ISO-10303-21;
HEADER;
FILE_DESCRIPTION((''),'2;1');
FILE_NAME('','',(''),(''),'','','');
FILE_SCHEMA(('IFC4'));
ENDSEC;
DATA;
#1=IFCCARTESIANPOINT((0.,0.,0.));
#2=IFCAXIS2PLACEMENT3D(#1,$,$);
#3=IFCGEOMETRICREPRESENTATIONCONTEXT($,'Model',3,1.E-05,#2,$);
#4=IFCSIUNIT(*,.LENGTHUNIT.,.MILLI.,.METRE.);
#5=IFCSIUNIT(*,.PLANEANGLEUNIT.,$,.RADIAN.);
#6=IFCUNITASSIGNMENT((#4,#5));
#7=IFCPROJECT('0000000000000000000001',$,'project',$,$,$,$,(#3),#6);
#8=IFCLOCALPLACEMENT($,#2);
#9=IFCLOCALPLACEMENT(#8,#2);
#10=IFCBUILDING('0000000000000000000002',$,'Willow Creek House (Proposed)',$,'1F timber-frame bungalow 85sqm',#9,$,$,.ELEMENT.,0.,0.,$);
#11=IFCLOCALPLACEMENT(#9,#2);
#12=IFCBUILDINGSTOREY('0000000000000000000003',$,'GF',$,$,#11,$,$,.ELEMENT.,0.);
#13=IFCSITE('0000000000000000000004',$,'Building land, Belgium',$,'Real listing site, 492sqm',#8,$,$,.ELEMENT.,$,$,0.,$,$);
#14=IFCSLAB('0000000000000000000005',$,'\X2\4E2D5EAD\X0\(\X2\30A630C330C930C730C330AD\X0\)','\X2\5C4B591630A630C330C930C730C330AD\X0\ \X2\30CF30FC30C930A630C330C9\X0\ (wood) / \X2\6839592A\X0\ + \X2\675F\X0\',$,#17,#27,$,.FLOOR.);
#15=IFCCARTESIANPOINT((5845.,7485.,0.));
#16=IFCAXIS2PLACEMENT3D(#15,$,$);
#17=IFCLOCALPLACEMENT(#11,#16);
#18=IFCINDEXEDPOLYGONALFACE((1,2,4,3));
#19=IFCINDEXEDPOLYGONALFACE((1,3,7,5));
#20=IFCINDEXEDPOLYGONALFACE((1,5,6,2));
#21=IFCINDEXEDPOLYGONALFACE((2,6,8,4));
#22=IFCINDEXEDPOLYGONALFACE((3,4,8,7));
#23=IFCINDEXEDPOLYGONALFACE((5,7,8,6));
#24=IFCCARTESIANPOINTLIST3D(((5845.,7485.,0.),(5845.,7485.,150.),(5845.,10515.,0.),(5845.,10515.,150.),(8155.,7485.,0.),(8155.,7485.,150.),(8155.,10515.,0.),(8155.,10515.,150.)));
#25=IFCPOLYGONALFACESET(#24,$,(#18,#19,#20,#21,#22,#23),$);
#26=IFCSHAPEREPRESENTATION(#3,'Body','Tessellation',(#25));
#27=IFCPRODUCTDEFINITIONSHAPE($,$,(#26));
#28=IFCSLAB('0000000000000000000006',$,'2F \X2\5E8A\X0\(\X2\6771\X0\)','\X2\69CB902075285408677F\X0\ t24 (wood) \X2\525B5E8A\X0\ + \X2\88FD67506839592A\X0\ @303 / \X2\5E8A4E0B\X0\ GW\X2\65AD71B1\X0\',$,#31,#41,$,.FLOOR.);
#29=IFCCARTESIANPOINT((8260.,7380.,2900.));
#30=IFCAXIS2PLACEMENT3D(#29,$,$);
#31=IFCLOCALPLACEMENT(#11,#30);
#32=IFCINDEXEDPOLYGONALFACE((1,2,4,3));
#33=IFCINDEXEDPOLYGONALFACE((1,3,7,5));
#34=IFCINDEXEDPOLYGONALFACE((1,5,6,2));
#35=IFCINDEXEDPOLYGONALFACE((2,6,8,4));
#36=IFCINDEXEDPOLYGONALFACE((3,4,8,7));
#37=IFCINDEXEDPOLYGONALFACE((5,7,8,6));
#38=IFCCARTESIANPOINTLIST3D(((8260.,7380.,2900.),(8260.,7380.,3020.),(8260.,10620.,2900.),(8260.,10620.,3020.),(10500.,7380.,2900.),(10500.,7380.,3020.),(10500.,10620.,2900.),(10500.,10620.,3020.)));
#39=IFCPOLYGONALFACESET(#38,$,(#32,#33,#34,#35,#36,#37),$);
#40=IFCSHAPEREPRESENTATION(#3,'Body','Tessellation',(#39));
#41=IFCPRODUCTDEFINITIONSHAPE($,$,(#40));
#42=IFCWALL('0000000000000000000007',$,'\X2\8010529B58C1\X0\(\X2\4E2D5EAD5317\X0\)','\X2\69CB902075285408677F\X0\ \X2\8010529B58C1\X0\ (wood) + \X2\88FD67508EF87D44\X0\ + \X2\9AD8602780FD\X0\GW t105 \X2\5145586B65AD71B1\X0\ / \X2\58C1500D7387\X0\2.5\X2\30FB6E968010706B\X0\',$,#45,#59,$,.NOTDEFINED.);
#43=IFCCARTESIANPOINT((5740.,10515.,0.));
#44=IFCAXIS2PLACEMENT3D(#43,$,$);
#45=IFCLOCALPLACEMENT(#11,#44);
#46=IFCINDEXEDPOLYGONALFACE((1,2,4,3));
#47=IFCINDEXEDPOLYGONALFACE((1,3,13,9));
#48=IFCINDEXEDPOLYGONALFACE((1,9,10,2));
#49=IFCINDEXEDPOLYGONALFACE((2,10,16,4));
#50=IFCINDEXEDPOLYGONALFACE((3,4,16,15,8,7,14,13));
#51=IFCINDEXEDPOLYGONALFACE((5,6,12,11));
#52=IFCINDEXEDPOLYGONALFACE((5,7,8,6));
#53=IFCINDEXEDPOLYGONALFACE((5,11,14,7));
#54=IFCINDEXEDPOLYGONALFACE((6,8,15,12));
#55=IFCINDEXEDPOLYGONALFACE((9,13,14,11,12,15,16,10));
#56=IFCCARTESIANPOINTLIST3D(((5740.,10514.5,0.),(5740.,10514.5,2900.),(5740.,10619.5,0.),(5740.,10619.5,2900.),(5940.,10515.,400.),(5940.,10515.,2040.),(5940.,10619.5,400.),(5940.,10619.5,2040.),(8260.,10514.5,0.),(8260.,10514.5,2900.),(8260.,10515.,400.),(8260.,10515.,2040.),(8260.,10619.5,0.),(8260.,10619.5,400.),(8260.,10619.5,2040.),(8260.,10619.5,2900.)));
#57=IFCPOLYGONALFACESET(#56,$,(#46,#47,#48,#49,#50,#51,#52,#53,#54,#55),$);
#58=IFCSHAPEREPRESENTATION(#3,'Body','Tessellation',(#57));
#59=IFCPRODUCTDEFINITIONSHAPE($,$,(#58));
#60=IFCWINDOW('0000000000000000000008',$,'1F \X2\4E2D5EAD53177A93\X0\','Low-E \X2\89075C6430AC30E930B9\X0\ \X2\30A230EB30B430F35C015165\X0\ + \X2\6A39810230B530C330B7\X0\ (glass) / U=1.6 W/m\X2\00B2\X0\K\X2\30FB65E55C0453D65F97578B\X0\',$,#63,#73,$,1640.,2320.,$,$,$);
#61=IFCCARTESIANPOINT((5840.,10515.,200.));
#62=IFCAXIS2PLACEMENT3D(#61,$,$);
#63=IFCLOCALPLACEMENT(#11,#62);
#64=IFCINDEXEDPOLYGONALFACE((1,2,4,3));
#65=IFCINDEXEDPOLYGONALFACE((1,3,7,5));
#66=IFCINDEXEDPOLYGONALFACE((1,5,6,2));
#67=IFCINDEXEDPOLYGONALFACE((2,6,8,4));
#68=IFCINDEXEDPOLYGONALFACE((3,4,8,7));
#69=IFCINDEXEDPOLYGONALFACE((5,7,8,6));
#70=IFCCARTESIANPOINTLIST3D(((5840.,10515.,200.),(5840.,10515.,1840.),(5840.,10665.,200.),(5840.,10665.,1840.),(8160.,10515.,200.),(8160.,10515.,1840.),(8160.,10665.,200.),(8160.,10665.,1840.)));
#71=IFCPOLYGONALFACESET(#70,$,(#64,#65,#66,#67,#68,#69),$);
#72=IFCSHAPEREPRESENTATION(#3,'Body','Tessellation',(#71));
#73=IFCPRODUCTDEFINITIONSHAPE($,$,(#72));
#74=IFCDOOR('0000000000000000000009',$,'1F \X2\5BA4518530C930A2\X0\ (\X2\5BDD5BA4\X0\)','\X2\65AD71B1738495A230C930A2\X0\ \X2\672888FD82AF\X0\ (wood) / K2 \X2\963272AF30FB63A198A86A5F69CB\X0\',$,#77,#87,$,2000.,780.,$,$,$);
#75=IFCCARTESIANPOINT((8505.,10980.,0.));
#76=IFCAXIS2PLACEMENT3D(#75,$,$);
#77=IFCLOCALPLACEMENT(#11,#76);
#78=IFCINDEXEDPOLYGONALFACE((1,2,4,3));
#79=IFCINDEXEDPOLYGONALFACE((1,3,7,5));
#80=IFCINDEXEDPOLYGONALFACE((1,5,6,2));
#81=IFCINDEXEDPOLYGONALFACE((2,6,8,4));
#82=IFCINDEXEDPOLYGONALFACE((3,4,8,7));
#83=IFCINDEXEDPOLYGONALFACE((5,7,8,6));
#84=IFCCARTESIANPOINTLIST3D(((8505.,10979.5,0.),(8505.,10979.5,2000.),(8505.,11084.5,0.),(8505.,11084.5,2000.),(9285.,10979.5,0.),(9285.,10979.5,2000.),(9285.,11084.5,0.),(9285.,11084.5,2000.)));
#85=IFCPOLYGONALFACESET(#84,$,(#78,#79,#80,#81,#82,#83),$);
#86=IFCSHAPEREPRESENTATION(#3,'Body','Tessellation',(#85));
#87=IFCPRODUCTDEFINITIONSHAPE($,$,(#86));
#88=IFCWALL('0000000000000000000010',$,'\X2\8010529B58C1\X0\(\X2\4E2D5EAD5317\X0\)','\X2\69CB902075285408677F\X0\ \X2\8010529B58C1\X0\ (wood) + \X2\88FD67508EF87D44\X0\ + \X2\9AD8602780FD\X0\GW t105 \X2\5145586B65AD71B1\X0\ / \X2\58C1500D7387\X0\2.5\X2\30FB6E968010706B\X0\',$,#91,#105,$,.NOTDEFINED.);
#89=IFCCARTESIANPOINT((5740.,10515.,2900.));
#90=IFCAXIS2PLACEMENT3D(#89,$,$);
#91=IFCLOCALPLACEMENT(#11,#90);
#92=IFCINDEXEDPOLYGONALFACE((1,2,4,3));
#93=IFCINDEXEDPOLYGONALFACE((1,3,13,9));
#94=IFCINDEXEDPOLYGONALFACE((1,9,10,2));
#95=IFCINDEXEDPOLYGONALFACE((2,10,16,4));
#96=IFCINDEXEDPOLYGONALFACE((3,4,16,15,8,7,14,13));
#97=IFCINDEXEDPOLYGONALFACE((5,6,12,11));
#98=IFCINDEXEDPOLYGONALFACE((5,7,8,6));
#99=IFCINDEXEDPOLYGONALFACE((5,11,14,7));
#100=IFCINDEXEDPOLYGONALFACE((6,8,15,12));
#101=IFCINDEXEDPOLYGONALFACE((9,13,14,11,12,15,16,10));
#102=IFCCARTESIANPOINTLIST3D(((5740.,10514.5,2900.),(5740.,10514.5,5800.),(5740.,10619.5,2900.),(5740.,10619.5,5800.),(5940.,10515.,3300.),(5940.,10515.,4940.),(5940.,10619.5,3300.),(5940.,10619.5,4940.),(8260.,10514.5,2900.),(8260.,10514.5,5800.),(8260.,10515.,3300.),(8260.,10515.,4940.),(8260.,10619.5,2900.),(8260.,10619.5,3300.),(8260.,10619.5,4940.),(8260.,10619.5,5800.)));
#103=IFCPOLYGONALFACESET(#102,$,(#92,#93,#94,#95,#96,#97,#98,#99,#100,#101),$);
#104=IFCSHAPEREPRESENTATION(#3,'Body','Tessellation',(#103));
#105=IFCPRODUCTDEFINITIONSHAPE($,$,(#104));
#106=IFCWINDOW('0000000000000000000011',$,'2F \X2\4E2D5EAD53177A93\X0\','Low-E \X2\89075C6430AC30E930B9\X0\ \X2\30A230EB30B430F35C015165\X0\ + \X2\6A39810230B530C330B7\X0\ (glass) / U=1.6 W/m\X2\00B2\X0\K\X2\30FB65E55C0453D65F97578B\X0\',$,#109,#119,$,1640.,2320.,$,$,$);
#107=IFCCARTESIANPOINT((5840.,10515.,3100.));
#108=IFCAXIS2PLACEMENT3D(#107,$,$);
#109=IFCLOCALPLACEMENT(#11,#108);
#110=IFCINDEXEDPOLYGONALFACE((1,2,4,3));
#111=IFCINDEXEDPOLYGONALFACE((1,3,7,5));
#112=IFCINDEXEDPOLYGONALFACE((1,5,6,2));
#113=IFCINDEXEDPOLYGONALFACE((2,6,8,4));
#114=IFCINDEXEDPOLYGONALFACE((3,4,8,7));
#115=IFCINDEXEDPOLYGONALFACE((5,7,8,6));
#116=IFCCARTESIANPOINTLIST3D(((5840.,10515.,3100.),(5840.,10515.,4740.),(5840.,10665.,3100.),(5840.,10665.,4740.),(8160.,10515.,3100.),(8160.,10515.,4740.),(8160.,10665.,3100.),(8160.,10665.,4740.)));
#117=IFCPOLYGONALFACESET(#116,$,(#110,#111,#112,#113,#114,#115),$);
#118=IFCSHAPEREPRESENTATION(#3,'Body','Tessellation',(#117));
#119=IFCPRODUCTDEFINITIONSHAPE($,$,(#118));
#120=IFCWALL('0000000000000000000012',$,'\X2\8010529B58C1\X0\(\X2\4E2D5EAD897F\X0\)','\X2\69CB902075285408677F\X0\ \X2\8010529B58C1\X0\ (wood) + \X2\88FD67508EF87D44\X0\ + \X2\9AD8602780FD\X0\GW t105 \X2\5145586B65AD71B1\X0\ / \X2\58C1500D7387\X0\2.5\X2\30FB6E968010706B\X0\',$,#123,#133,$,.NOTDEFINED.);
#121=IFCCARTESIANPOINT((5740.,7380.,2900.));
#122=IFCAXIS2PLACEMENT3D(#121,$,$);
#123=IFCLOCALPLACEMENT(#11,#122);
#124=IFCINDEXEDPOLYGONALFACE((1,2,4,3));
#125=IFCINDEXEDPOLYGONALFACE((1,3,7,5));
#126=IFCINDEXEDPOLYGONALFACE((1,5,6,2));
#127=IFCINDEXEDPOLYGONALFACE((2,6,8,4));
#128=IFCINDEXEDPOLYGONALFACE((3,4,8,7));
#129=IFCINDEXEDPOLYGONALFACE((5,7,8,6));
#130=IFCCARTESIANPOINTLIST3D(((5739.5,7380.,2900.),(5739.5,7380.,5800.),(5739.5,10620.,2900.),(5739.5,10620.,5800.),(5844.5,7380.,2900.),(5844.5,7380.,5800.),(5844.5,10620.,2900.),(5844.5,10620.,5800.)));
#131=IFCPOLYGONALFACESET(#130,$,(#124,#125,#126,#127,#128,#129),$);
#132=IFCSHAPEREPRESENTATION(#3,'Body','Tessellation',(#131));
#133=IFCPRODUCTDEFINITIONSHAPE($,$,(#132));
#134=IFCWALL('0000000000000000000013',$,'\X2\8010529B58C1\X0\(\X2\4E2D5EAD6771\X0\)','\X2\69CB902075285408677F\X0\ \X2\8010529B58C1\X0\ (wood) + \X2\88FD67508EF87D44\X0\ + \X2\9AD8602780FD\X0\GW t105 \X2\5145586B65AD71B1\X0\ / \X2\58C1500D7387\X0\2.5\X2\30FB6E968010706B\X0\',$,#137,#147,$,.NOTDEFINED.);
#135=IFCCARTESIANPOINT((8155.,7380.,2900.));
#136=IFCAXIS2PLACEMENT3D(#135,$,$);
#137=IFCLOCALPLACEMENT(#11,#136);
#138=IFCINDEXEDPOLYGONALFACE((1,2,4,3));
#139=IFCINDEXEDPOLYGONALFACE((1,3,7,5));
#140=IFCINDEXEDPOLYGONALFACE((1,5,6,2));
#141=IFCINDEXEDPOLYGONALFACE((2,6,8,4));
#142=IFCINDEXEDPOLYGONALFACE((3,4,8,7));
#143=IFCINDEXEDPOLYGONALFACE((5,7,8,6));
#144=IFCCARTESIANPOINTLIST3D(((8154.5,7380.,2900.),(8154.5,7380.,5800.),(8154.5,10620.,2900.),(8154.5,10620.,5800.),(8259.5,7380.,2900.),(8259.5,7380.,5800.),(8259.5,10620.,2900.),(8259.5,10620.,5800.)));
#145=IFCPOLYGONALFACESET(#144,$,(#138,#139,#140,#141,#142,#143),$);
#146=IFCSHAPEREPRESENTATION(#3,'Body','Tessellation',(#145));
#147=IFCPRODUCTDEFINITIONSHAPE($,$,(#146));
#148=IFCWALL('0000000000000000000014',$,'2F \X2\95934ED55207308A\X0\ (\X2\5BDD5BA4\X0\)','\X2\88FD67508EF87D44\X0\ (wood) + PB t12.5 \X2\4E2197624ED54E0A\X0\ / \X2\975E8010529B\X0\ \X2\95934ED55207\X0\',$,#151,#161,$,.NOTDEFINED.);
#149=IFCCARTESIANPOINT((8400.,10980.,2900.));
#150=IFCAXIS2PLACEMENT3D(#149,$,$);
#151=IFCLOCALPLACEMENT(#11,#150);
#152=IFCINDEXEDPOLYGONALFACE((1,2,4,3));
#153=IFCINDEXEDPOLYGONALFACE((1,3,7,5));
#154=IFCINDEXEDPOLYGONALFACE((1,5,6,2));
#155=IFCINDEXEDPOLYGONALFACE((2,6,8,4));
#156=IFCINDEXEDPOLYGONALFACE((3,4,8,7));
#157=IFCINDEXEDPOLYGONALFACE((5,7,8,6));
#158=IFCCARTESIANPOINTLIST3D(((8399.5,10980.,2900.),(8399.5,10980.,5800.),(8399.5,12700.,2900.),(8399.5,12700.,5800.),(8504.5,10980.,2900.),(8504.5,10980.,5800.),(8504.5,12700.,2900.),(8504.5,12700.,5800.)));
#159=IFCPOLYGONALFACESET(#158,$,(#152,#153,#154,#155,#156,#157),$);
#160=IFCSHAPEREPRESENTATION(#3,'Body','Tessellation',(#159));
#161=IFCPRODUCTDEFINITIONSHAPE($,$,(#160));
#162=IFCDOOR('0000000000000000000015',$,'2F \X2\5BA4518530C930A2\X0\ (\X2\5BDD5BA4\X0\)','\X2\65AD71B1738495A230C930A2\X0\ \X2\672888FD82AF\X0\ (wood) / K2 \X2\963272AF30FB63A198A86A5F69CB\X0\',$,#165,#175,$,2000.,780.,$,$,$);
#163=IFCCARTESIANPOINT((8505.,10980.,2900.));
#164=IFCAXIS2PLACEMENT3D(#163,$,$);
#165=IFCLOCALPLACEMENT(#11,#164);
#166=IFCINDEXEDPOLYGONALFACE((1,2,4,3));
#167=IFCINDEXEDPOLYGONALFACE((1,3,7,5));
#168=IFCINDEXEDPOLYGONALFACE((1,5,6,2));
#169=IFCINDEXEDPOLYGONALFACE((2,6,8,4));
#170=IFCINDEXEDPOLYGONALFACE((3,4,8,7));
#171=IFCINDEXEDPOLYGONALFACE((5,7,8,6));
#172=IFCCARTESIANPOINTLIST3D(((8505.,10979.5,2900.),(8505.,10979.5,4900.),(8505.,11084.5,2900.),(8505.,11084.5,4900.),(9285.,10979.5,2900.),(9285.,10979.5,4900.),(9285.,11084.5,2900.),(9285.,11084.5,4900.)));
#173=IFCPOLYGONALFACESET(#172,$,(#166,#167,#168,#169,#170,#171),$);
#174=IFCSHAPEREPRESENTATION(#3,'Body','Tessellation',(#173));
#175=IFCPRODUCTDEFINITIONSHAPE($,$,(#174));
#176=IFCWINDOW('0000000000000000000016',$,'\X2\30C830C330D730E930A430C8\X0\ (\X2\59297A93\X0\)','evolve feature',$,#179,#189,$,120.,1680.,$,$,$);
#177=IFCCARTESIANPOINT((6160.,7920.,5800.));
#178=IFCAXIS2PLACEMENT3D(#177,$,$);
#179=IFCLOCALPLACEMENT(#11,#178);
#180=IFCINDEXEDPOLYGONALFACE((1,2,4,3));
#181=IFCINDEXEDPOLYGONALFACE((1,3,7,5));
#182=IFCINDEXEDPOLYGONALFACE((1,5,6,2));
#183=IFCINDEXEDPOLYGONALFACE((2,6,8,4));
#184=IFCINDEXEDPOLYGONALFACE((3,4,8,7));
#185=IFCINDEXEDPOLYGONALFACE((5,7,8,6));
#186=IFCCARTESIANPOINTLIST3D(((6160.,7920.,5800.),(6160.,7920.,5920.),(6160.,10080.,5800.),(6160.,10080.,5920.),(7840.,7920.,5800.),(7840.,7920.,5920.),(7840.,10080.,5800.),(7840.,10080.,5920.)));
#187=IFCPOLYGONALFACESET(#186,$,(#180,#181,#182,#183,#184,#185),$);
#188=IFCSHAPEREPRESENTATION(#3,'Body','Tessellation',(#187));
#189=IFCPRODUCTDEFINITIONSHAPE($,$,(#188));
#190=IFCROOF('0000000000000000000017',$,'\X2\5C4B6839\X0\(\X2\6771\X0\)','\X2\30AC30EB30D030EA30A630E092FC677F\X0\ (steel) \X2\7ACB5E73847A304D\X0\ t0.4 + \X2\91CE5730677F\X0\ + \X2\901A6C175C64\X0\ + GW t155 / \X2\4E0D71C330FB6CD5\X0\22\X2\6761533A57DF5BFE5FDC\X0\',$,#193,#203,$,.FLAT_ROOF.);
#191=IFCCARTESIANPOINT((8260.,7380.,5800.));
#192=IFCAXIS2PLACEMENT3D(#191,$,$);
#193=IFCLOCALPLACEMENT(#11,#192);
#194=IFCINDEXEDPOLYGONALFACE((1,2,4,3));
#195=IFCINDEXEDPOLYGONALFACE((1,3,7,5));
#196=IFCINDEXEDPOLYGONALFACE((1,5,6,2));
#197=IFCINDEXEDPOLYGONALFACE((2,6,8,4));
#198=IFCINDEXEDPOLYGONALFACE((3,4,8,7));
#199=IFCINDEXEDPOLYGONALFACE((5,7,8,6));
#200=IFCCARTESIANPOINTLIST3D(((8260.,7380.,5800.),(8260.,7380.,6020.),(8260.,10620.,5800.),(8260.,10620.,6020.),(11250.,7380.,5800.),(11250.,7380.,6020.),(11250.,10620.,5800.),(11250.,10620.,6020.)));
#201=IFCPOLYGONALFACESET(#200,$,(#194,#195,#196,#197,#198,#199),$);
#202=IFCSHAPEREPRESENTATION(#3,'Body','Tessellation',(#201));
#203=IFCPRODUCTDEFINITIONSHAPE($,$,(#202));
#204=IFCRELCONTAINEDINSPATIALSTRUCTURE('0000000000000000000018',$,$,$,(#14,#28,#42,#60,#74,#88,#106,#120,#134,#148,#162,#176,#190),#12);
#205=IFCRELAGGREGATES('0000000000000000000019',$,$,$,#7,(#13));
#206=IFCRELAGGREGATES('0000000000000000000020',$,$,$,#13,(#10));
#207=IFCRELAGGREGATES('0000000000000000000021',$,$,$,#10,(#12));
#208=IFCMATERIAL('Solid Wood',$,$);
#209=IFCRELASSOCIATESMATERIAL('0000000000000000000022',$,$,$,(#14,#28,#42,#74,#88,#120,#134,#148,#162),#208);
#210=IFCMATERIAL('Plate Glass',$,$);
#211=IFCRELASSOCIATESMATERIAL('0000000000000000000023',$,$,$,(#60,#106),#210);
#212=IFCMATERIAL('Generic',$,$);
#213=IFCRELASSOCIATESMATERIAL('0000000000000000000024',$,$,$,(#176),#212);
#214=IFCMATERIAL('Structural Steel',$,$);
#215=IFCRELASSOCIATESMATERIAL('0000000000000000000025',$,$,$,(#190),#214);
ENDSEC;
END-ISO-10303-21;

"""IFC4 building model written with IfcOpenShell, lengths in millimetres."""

from ifc_helpers import new_model, si_unit, frame, frame_2d, origin, place, context, project, spatial, rectangle, extrude, material, element, fill, save


model = new_model("IFC4")

# Units and contexts
model_context = context("Model", 3, precision=1e-05, world=origin())
ifc_project = project(units=[si_unit("LENGTHUNIT", "METRE", prefix="MILLI"), si_unit("PLANEANGLEUNIT", "RADIAN")], contexts=[model_context])

# Site, building, storey
site_placement = place(None, origin())
site = spatial("IfcSite", under=ifc_project, at=site_placement, Name="Building land, Belgium", ObjectType="Real listing site, 492sqm", CompositionType="ELEMENT", RefElevation=0.0)
building_placement = place(site_placement, origin())
building = spatial("IfcBuilding", under=site, at=building_placement, Name="Willow Creek House (Proposed)", ObjectType="1F timber-frame bungalow 85sqm", CompositionType="ELEMENT", ElevationOfRefHeight=0.0, ElevationOfTerrain=0.0)
storey_placement = place(building_placement, origin())
storey = spatial("IfcBuildingStorey", under=building, at=storey_placement, Name="GF", CompositionType="ELEMENT", Elevation=0.0)

# Slabs
ifc_material_1 = material(Name="Solid Wood")
slab_1_placement = place(storey_placement, frame((5845.0, 7485.0, 0.0)))
element("IfcSlab", 1, at=slab_1_placement, inside=storey, material=ifc_material_1, Name="中庭(ウッドデッキ)", Description="屋外ウッドデッキ ハードウッド (wood) / 根太 + 束", PredefinedType="FLOOR", context=model_context, shape_type="SweptSolid", body=[
    extrude(rectangle(XDim=2310.0, YDim=3030.0, at=frame_2d((1155.0, 1515.0))), frame((5845.0, 7485.0, 0.0)), (0.0, 0.0, 1.0), 150.0),
])
slab_2_placement = place(storey_placement, frame((8260.0, 7380.0, 2900.0)))
element("IfcSlab", 2, at=slab_2_placement, inside=storey, material=ifc_material_1, Name="2F 床(東)", Description="構造用合板 t24 (wood) 剛床 + 製材根太 @303 / 床下 GW断熱", PredefinedType="FLOOR", context=model_context, shape_type="SweptSolid", body=[
    extrude(rectangle(XDim=2240.0, YDim=3240.0, at=frame_2d((1120.0, 1620.0))), frame((8260.0, 7380.0, 2900.0)), (0.0, 0.0, 1.0), 120.0),
])

# Wall, opening, window
wall_1_placement = place(storey_placement, frame((5740.0, 10515.0, 0.0)))
wall_1 = element("IfcWall", 3, at=wall_1_placement, inside=storey, material=ifc_material_1, Name="耐力壁(中庭北)", Description="構造用合板 耐力壁 (wood) + 製材軸組 + 高性能GW t105 充填断熱 / 壁倍率2.5・準耐火", PredefinedType="NOTDEFINED", context=model_context, shape_type="SweptSolid", body=[
    extrude(rectangle(XDim=2520.0, YDim=105.0, at=frame_2d((1260.0, 52.0))), frame((5740.0, 10515.0, 0.0)), (0.0, 0.0, 1.0), 2900.0),
])
opening_1_placement = place(storey_placement, frame((5840.0, 10515.0, 200.0)))
opening_1 = element("IfcOpeningElement", 4, at=opening_1_placement, cuts=wall_1, PredefinedType="NOTDEFINED", context=model_context, shape_type="SweptSolid", body=[
    extrude(rectangle(XDim=2320.0, YDim=150.0, at=frame_2d((1160.0, 75.0))), frame((5840.0, 10515.0, 200.0)), (0.0, 0.0, 1.0), 1640.0),
])
ifc_material_2 = material(Name="Plate Glass")
window_1_placement = place(storey_placement, frame((5840.0, 10515.0, 200.0)))
window_1 = element("IfcWindow", 5, at=window_1_placement, inside=storey, material=ifc_material_2, Name="1F 中庭北窓", Description="Low-E 複層ガラス アルゴン封入 + 樹脂サッシ (glass) / U=1.6 W/m²K・日射取得型", OverallHeight=1640.0, OverallWidth=2320.0, context=model_context, shape_type="SweptSolid", body=[
    extrude(rectangle(XDim=2320.0, YDim=150.0, at=frame_2d((1160.0, 75.0))), frame((5840.0, 10515.0, 200.0)), (0.0, 0.0, 1.0), 1640.0),
])
fill(opening_1, window_1)

# Door
door_1_placement = place(storey_placement, frame((8505.0, 10980.0, 0.0)))
element("IfcDoor", 6, at=door_1_placement, inside=storey, material=ifc_material_1, Name="1F 室内ドア (寝室)", Description="断熱玄関ドア 木製芯 (wood) / K2 防犯・採風機構", OverallHeight=2000.0, OverallWidth=780.0, context=model_context, shape_type="SweptSolid", body=[
    extrude(rectangle(XDim=780.0, YDim=105.0, at=frame_2d((390.0, 52.0))), frame((8505.0, 10980.0, 0.0)), (0.0, 0.0, 1.0), 2000.0),
])

# Wall, opening, window
wall_2_placement = place(storey_placement, frame((5740.0, 10515.0, 2900.0)))
wall_2 = element("IfcWall", 7, at=wall_2_placement, inside=storey, material=ifc_material_1, Name="耐力壁(中庭北)", Description="構造用合板 耐力壁 (wood) + 製材軸組 + 高性能GW t105 充填断熱 / 壁倍率2.5・準耐火", PredefinedType="NOTDEFINED", context=model_context, shape_type="SweptSolid", body=[
    extrude(rectangle(XDim=2520.0, YDim=105.0, at=frame_2d((1260.0, 52.0))), frame((5740.0, 10515.0, 2900.0)), (0.0, 0.0, 1.0), 2900.0),
])
opening_2_placement = place(storey_placement, frame((5840.0, 10515.0, 3100.0)))
opening_2 = element("IfcOpeningElement", 8, at=opening_2_placement, cuts=wall_2, PredefinedType="NOTDEFINED", context=model_context, shape_type="SweptSolid", body=[
    extrude(rectangle(XDim=2320.0, YDim=150.0, at=frame_2d((1160.0, 75.0))), frame((5840.0, 10515.0, 3100.0)), (0.0, 0.0, 1.0), 1640.0),
])
window_2_placement = place(storey_placement, frame((5840.0, 10515.0, 3100.0)))
window_2 = element("IfcWindow", 9, at=window_2_placement, inside=storey, material=ifc_material_2, Name="2F 中庭北窓", Description="Low-E 複層ガラス アルゴン封入 + 樹脂サッシ (glass) / U=1.6 W/m²K・日射取得型", OverallHeight=1640.0, OverallWidth=2320.0, context=model_context, shape_type="SweptSolid", body=[
    extrude(rectangle(XDim=2320.0, YDim=150.0, at=frame_2d((1160.0, 75.0))), frame((5840.0, 10515.0, 3100.0)), (0.0, 0.0, 1.0), 1640.0),
])
fill(opening_2, window_2)

# Walls
wall_3_placement = place(storey_placement, frame((5740.0, 7380.0, 2900.0)))
element("IfcWall", 10, at=wall_3_placement, inside=storey, material=ifc_material_1, Name="耐力壁(中庭西)", Description="構造用合板 耐力壁 (wood) + 製材軸組 + 高性能GW t105 充填断熱 / 壁倍率2.5・準耐火", PredefinedType="NOTDEFINED", context=model_context, shape_type="SweptSolid", body=[
    extrude(rectangle(XDim=105.0, YDim=3240.0, at=frame_2d((52.0, 1620.0))), frame((5740.0, 7380.0, 2900.0)), (0.0, 0.0, 1.0), 2900.0),
])
wall_4_placement = place(storey_placement, frame((8155.0, 7380.0, 2900.0)))
element("IfcWall", 11, at=wall_4_placement, inside=storey, material=ifc_material_1, Name="耐力壁(中庭東)", Description="構造用合板 耐力壁 (wood) + 製材軸組 + 高性能GW t105 充填断熱 / 壁倍率2.5・準耐火", PredefinedType="NOTDEFINED", context=model_context, shape_type="SweptSolid", body=[
    extrude(rectangle(XDim=105.0, YDim=3240.0, at=frame_2d((52.0, 1620.0))), frame((8155.0, 7380.0, 2900.0)), (0.0, 0.0, 1.0), 2900.0),
])
wall_5_placement = place(storey_placement, frame((8400.0, 10980.0, 2900.0)))
element("IfcWall", 12, at=wall_5_placement, inside=storey, material=ifc_material_1, Name="2F 間仕切り (寝室)", Description="製材軸組 (wood) + PB t12.5 両面仕上 / 非耐力 間仕切", PredefinedType="NOTDEFINED", context=model_context, shape_type="SweptSolid", body=[
    extrude(rectangle(XDim=105.0, YDim=1720.0, at=frame_2d((52.0, 860.0))), frame((8400.0, 10980.0, 2900.0)), (0.0, 0.0, 1.0), 2900.0),
])

# Door
door_2_placement = place(storey_placement, frame((8505.0, 10980.0, 2900.0)))
element("IfcDoor", 13, at=door_2_placement, inside=storey, material=ifc_material_1, Name="2F 室内ドア (寝室)", Description="断熱玄関ドア 木製芯 (wood) / K2 防犯・採風機構", OverallHeight=2000.0, OverallWidth=780.0, context=model_context, shape_type="SweptSolid", body=[
    extrude(rectangle(XDim=780.0, YDim=105.0, at=frame_2d((390.0, 52.0))), frame((8505.0, 10980.0, 2900.0)), (0.0, 0.0, 1.0), 2000.0),
])

# Window
ifc_material_3 = material(Name="Generic")
window_3_placement = place(storey_placement, frame((6160.0, 7920.0, 5800.0)))
element("IfcWindow", 14, at=window_3_placement, inside=storey, material=ifc_material_3, Name="トップライト (天窓)", Description="evolve feature", OverallHeight=120.0, OverallWidth=1680.0, context=model_context, shape_type="SweptSolid", body=[
    extrude(rectangle(XDim=1680.0, YDim=2160.0, at=frame_2d((840.0, 1080.0))), frame((6160.0, 7920.0, 5800.0)), (0.0, 0.0, 1.0), 120.0),
])

# Roof
ifc_material_4 = material(Name="Structural Steel")
roof_placement = place(storey_placement, frame((8260.0, 7380.0, 5800.0)))
element("IfcRoof", 15, at=roof_placement, inside=storey, material=ifc_material_4, Name="屋根(東)", Description="ガルバリウム鋼板 (steel) 立平葺き t0.4 + 野地板 + 通気層 + GW t155 / 不燃・法22条区域対応", PredefinedType="FLAT_ROOF", context=model_context, shape_type="SweptSolid", body=[
    extrude(rectangle(XDim=2990.0, YDim=3240.0, at=frame_2d((1495.0, 1620.0))), frame((8260.0, 7380.0, 5800.0)), (0.0, 0.0, 1.0), 220.0),
])

save(model, "model.ifc")
